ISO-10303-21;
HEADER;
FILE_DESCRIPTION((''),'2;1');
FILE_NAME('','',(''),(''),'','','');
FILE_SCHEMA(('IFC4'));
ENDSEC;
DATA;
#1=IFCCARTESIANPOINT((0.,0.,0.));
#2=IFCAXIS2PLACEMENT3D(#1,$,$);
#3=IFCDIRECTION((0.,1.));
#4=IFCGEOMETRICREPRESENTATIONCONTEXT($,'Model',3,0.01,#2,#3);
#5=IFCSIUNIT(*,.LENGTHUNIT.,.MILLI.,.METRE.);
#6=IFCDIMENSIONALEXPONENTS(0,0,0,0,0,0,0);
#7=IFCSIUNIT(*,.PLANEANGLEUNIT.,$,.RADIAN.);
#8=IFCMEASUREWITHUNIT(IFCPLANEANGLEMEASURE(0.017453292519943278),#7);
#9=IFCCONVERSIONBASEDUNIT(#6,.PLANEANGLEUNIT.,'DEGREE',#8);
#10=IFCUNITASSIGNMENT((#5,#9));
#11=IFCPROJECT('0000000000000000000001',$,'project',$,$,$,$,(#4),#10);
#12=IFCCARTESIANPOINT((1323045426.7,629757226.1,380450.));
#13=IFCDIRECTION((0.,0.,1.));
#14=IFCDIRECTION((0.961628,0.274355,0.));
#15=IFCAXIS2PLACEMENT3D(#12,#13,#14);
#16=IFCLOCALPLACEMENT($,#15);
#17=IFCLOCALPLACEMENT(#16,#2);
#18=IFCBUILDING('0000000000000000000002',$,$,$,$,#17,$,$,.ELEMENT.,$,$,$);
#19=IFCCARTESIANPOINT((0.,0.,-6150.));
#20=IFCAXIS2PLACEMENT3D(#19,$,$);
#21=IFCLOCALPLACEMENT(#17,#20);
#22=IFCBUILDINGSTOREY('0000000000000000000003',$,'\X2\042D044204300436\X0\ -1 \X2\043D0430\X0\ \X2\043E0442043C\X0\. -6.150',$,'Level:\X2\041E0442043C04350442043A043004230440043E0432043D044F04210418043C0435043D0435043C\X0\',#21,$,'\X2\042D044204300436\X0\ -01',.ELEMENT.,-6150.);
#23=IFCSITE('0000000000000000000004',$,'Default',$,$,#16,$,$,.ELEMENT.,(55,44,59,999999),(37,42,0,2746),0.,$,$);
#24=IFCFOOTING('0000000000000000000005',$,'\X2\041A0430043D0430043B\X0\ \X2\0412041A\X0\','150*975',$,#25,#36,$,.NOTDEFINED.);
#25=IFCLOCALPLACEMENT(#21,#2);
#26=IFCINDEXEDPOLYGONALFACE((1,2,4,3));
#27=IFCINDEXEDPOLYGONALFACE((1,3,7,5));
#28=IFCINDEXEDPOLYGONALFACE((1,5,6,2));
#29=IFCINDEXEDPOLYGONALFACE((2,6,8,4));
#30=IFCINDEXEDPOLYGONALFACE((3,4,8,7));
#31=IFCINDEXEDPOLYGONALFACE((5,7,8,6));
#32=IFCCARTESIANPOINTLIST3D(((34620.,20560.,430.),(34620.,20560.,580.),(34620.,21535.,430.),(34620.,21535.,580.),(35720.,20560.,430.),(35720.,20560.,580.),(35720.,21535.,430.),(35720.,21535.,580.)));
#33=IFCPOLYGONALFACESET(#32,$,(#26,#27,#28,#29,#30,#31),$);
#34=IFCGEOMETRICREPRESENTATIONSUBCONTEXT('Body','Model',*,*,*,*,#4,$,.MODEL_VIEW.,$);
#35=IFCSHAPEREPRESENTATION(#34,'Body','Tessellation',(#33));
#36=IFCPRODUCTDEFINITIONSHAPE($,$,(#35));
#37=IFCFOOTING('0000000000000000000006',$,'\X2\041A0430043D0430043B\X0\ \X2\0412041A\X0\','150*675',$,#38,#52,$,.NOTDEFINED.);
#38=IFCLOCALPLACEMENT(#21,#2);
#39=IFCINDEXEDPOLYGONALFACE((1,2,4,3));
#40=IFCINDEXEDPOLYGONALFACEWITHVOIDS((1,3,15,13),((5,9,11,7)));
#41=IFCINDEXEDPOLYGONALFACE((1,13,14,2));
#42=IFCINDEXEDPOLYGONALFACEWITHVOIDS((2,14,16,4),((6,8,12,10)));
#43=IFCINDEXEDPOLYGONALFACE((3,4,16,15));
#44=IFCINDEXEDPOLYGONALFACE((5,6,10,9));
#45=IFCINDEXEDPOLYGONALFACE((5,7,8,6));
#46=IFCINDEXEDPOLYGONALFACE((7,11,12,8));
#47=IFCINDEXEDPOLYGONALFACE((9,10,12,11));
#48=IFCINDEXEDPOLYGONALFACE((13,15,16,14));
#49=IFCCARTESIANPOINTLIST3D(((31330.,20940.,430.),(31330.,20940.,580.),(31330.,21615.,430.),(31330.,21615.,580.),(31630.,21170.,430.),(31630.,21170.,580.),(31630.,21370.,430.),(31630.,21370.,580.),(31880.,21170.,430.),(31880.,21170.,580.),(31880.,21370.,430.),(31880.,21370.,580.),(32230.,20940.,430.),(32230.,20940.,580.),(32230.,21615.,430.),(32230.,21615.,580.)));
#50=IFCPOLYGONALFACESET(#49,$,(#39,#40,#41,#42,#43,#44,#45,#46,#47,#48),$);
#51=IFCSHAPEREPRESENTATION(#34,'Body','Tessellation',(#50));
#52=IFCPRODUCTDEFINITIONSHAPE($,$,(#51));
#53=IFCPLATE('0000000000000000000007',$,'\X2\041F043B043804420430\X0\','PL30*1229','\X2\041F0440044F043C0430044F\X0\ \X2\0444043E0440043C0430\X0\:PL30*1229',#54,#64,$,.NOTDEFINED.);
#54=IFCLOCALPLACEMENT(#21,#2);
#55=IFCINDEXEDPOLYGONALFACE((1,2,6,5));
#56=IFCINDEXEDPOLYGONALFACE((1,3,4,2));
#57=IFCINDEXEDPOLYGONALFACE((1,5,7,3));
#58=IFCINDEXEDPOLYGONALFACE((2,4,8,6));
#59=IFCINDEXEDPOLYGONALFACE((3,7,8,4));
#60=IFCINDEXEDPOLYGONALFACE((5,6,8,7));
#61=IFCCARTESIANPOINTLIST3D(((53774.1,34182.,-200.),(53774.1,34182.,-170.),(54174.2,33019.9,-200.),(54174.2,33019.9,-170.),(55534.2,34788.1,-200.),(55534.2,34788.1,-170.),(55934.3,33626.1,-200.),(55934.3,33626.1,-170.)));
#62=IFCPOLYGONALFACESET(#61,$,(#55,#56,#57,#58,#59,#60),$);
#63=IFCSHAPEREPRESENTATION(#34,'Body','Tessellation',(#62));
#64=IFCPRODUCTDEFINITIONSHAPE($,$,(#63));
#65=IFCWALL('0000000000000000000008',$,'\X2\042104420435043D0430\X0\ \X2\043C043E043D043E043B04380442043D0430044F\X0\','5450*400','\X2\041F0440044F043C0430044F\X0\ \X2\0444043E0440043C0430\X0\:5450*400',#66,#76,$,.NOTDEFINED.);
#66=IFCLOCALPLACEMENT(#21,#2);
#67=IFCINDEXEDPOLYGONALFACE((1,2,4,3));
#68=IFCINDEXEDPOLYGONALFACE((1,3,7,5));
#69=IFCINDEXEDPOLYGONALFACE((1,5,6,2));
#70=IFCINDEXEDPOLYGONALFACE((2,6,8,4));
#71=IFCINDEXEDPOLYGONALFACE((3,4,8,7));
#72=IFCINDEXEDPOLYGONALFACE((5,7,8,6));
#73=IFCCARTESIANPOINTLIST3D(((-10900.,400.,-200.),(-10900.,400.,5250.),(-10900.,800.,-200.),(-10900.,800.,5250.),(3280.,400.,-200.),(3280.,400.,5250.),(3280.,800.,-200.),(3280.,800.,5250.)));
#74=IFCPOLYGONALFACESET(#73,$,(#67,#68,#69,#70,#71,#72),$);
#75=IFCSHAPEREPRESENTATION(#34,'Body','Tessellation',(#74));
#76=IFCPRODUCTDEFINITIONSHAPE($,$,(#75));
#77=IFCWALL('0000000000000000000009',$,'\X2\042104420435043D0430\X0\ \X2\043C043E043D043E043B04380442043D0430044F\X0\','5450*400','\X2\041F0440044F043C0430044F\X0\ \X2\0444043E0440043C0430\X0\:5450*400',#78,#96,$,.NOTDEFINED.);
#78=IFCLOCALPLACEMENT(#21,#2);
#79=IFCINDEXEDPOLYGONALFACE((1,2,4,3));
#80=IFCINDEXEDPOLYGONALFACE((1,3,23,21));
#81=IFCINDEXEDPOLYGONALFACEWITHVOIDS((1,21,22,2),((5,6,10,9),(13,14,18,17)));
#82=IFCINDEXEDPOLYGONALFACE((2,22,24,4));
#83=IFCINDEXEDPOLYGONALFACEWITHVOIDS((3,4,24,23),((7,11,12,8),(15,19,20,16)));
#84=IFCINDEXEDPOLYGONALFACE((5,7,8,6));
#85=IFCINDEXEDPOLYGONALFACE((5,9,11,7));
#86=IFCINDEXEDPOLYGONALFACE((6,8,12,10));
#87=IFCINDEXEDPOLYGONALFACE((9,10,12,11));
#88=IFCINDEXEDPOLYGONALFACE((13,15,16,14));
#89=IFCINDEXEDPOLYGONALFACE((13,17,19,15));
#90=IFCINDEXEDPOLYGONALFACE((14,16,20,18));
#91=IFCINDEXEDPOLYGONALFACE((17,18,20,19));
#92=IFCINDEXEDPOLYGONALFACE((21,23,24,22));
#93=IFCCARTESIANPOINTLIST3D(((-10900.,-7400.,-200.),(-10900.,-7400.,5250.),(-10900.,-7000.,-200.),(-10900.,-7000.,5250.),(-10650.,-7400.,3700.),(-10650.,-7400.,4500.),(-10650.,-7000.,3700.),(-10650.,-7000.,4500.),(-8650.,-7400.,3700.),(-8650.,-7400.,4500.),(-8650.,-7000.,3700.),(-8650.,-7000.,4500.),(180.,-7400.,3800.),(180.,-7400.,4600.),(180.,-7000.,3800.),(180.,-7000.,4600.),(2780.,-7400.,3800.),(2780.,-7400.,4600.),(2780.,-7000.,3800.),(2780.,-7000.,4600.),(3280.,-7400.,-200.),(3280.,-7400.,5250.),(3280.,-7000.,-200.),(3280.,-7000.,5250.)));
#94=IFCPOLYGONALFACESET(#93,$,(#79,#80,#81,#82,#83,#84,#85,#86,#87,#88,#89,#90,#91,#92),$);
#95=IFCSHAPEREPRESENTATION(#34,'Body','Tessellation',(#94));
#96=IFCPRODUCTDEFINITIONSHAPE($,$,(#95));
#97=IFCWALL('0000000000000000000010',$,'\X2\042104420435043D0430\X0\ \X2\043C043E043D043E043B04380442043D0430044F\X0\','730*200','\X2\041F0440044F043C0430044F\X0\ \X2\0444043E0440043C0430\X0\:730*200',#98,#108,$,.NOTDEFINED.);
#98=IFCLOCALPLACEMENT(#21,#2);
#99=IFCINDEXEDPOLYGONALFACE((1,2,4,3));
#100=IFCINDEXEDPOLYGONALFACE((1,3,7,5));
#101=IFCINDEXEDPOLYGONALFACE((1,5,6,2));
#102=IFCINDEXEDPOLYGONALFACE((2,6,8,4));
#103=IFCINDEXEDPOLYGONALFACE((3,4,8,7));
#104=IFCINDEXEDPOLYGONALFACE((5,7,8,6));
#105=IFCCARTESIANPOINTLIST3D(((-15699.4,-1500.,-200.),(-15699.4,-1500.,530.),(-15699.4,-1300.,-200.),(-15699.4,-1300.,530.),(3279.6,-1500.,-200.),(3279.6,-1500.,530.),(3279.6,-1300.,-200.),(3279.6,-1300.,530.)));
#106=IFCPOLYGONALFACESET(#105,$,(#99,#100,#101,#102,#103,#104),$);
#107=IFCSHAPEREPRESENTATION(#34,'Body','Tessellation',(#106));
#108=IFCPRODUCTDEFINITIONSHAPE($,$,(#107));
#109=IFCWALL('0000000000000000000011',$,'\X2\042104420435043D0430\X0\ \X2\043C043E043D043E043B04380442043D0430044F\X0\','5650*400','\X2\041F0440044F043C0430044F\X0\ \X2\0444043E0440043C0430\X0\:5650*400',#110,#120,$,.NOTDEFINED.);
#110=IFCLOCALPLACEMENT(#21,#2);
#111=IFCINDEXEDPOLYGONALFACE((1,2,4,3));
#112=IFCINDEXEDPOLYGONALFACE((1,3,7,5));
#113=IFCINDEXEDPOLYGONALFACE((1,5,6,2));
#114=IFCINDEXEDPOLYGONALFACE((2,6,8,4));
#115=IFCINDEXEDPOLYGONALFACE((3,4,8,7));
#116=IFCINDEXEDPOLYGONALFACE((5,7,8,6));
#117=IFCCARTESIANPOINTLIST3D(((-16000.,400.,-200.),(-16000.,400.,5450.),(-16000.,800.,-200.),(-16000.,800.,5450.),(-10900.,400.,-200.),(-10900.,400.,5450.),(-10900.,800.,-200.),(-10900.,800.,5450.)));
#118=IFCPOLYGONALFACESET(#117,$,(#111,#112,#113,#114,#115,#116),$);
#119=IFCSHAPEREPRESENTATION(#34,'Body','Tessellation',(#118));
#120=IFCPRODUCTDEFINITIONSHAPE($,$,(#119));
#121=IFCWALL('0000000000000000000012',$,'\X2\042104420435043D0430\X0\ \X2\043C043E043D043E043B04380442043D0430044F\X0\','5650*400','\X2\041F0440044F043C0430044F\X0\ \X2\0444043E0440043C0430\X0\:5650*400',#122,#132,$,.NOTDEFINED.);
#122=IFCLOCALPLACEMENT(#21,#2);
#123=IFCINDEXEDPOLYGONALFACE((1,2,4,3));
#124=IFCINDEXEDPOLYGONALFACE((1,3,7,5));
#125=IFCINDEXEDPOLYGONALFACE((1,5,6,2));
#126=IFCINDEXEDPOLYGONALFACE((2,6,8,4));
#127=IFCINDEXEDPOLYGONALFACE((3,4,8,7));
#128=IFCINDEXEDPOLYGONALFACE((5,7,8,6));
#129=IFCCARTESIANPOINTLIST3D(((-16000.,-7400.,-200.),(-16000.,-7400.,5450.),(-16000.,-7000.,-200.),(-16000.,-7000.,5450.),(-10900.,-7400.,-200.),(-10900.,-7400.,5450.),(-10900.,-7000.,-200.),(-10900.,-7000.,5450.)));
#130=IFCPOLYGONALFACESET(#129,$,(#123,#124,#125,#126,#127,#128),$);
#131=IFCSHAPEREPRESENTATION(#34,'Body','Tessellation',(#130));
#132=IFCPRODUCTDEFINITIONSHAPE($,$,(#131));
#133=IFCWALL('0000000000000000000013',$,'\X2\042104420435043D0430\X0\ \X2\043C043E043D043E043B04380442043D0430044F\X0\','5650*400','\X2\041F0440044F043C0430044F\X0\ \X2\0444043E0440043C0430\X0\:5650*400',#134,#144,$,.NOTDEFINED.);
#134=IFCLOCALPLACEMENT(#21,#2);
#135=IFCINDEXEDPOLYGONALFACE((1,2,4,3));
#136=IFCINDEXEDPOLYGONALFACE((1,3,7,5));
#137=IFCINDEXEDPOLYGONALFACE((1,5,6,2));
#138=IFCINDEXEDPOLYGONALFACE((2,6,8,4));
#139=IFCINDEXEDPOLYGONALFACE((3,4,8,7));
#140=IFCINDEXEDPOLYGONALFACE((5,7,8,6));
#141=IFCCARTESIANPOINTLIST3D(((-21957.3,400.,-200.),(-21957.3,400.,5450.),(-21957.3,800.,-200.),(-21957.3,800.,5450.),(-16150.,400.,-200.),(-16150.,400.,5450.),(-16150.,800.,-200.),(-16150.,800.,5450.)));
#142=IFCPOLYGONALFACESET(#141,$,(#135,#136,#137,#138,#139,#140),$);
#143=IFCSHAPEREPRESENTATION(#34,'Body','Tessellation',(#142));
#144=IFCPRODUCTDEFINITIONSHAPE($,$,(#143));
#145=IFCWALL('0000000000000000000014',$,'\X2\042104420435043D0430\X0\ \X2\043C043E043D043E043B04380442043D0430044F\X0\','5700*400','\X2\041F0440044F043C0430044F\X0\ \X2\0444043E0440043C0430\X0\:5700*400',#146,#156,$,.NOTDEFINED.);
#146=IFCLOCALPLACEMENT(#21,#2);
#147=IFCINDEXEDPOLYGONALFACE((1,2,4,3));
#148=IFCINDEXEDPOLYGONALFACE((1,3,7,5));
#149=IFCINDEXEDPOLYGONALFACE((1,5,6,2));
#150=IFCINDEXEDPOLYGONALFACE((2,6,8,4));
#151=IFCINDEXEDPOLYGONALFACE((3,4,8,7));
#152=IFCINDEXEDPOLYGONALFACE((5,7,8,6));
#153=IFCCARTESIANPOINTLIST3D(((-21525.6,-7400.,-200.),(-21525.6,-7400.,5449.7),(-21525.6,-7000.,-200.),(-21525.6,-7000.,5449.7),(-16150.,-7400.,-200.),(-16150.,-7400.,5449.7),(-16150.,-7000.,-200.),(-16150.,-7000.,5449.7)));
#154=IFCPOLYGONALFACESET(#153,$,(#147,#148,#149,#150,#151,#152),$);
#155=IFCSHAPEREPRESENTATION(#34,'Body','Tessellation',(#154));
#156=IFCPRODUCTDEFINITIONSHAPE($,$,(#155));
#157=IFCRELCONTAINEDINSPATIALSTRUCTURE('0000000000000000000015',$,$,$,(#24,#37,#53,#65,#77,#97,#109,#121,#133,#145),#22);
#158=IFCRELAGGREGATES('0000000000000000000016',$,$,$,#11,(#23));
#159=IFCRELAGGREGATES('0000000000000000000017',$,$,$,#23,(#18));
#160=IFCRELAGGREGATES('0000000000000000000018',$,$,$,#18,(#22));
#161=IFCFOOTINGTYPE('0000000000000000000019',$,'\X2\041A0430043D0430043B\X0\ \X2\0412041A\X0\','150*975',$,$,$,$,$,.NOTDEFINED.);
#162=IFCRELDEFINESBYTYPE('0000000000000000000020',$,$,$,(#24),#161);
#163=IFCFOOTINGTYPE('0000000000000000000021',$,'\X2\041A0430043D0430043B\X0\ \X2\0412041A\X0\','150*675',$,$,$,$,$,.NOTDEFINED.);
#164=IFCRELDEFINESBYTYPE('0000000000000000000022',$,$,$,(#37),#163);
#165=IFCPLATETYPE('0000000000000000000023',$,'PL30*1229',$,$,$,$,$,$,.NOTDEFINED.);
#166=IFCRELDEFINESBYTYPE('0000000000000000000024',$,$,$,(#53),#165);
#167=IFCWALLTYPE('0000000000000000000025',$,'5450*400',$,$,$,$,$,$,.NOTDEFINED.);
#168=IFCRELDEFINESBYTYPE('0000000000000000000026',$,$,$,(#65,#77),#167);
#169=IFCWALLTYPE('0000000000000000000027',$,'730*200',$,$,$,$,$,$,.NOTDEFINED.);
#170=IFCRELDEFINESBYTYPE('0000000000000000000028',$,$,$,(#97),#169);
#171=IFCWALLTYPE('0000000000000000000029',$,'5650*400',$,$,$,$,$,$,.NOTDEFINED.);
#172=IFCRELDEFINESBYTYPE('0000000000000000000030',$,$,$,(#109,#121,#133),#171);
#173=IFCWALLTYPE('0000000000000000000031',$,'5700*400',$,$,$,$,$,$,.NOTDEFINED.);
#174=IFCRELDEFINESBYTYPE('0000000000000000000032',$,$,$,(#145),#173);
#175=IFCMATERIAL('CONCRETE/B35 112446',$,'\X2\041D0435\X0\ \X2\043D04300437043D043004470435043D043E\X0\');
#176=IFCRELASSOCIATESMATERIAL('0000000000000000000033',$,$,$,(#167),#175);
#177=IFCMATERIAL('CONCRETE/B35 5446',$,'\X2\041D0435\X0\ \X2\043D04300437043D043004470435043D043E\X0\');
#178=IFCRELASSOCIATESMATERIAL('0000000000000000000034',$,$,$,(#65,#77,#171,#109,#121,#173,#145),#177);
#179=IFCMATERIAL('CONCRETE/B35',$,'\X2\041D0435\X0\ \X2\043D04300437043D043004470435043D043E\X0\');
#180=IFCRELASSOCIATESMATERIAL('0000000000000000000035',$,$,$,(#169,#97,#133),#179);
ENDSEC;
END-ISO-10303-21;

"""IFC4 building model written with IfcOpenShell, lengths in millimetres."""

from ifc_helpers import new_model, entity, si_unit, converted_unit, direction, frame, origin, place, context, subcontext, project, spatial, indexed_curve, outline, extrude, material, type_object, element, save


model = new_model("IFC4")

# Units and contexts
model_context = context("Model", 3, precision=0.01, world=origin(), true_north=direction((0.0, 1.0)))
body_context = subcontext(model_context, "Body", "Model", "MODEL_VIEW")
ifc_project = project(units=[si_unit("LENGTHUNIT", "METRE", prefix="MILLI"), converted_unit("PLANEANGLEUNIT", "DEGREE", entity("IfcPlaneAngleMeasure", 0.017453292519943278), si_unit("PLANEANGLEUNIT", "RADIAN"), dimensions=[0, 0, 0, 0, 0, 0, 0])], contexts=[model_context])

# Site, building, storey
site_placement = place(None, frame((1323045426.7, 629757226.1, 380450.0), z_axis=(0.0, 0.0, 1.0), x_axis=(0.961628, 0.274355, 0.0)))
site = spatial("IfcSite", under=ifc_project, at=site_placement, Name="Default", CompositionType="ELEMENT", RefLatitude=(55, 44, 59, 999999), RefLongitude=(37, 42, 0, 2746), RefElevation=0.0)
building_placement = place(site_placement, origin())
building = spatial("IfcBuilding", under=site, at=building_placement, CompositionType="ELEMENT")
storey_placement = place(building_placement, frame((0.0, 0.0, -6150.0)))
storey = spatial("IfcBuildingStorey", under=building, at=storey_placement, Name="Этаж -1 на отм. -6.150", ObjectType="Level:ОтметкаУровняСИменем", LongName="Этаж -01", CompositionType="ELEMENT", Elevation=-6150.0)

# Footings
footing_type_1 = type_object("IfcFootingType", Name="Канал ВК", Description="150*975", PredefinedType="NOTDEFINED")
footing_1_placement = place(storey_placement, origin())
element("IfcFooting", 1, at=footing_1_placement, inside=storey, type_object=footing_type_1, Name="Канал ВК", Description="150*975", PredefinedType="NOTDEFINED", context=body_context, shape_type="SweptSolid", body=[
    extrude(outline(indexed_curve([(-550.0, -487.5), (550.0, -487.5), (550.0, 487.5), (-550.0, 487.5), (-550.0, -487.5)], self_intersect=False)), frame((35170.0, 21047.5, 430.0), z_axis=(0.0, 0.0, 1.0), x_axis=(-1.0, 0.0, 0.0)), (0.0, 0.0, 1.0), 150.0),
])
footing_type_2 = type_object("IfcFootingType", Name="Канал ВК", Description="150*675", PredefinedType="NOTDEFINED")
footing_2_placement = place(storey_placement, origin())
element("IfcFooting", 2, at=footing_2_placement, inside=storey, type_object=footing_type_2, Name="Канал ВК", Description="150*675", PredefinedType="NOTDEFINED", context=body_context, shape_type="SweptSolid", body=[
    extrude(outline(indexed_curve([(-450.0, -337.5), (450.0, -337.5), (450.0, 337.5), (-450.0, 337.5), (-450.0, -337.5)], self_intersect=False), holes=[indexed_curve([(150.0, -92.5), (-100.0, -92.5), (-100.0, 107.5), (150.0, 107.5), (150.0, -92.5)], self_intersect=False)]), frame((31780.0, 21277.5, 430.0), z_axis=(0.0, 0.0, 1.0), x_axis=(-1.0, 0.0, 0.0)), (0.0, 0.0, 1.0), 150.0),
])

# Plate
plate_type_1 = type_object("IfcPlateType", Name="PL30*1229", PredefinedType="NOTDEFINED")
plate_1_placement = place(storey_placement, origin())
element("IfcPlate", 3, at=plate_1_placement, inside=storey, type_object=plate_type_1, Name="Плита", Description="PL30*1229", ObjectType="Прямая форма:PL30*1229", PredefinedType="NOTDEFINED", context=body_context, shape_type="SweptSolid", body=[
    extrude(outline(indexed_curve([(-930.8, -614.5), (930.7, -614.5), (930.8, 614.5), (-930.7, 614.5), (-930.8, -614.5)], self_intersect=False)), frame((54854.2, 33904.0, -200.0), z_axis=(0.0, 0.0, 1.0), x_axis=(0.945494, 0.325639, 0.0)), (0.0, 0.0, 1.0), 30.0),
])

# Wall
ifc_material_1 = material(Name="CONCRETE/B35 5446", Category="Не назначено")
ifc_material_2 = material(Name="CONCRETE/B35 112446", Category="Не назначено")
wall_type_1 = type_object("IfcWallType", Name="5450*400", PredefinedType="NOTDEFINED", material=ifc_material_2)
wall_1_placement = place(storey_placement, frame((-10900.0, 400.0, -200.0)))
element("IfcWall", 4, at=wall_1_placement, inside=storey, type_object=wall_type_1, material=ifc_material_1, Name="Стена монолитная", Description="5450*400", ObjectType="Прямая форма:5450*400", PredefinedType="NOTDEFINED", context=body_context, shape_type="SweptSolid", body=[
    extrude(outline(indexed_curve([(-200.0, -7090.0), (200.0, -7090.0), (200.0, 7090.0), (-200.0, 7090.0), (-200.0, -7090.0)], self_intersect=False)), frame((7090.0, 200.0, 0.0), z_axis=(0.0, 0.0, 1.0), x_axis=(0.0, -1.0, 0.0)), (0.0, 0.0, 1.0), 5450.0),
])

# Wall, openings
wall_2_placement = place(storey_placement, frame((-10900.0, -7400.0, -200.0)))
wall_2 = element("IfcWall", 5, at=wall_2_placement, inside=storey, type_object=wall_type_1, material=ifc_material_1, Name="Стена монолитная", Description="5450*400", ObjectType="Прямая форма:5450*400", PredefinedType="NOTDEFINED", context=body_context, shape_type="SweptSolid", body=[
    extrude(outline(indexed_curve([(-200.0, -7090.0), (200.0, -7090.0), (200.0, 7090.0), (-200.0, 7090.0), (-200.0, -7090.0)], self_intersect=False)), frame((7090.0, 200.0, 0.0), z_axis=(0.0, 0.0, 1.0), x_axis=(0.0, -1.0, 0.0)), (0.0, 0.0, 1.0), 5450.0),
])
opening_1_placement = place(storey_placement, frame((-10900.0, -7400.0, -200.0)))
element("IfcOpeningElement", 6, at=opening_1_placement, cuts=wall_2, PredefinedType="OPENING", context=body_context, shape_type="SweptSolid", body=[
    extrude(outline(indexed_curve([(-1300.0, -400.0), (1300.0, -400.0), (1300.0, 400.0), (-1300.0, 400.0), (-1300.0, -400.0)], self_intersect=False)), frame((12380.0, 400.0, 4400.0), z_axis=(0.0, -1.0, 0.0), x_axis=(1.0, 0.0, 0.0)), (0.0, 0.0, 1.0), 400.0),
])
opening_2_placement = place(storey_placement, frame((-10900.0, -7400.0, -200.0)))
element("IfcOpeningElement", 7, at=opening_2_placement, cuts=wall_2, PredefinedType="OPENING", context=body_context, shape_type="SweptSolid", body=[
    extrude(outline(indexed_curve([(-1000.0, -400.0), (1000.0, -400.0), (1000.0, 400.0), (-1000.0, 400.0), (-1000.0, -400.0)], self_intersect=False)), frame((1250.0, 400.0, 4300.0), z_axis=(0.0, -1.0, 0.0), x_axis=(1.0, 0.0, 0.0)), (0.0, 0.0, 1.0), 400.0),
])

# Walls
ifc_material_3 = material(Name="CONCRETE/B35", Category="Не назначено")
wall_type_2 = type_object("IfcWallType", Name="730*200", PredefinedType="NOTDEFINED", material=ifc_material_3)
wall_3_placement = place(storey_placement, frame((-15699.4, -1500.0, -200.0)))
element("IfcWall", 8, at=wall_3_placement, inside=storey, type_object=wall_type_2, material=ifc_material_3, Name="Стена монолитная", Description="730*200", ObjectType="Прямая форма:730*200", PredefinedType="NOTDEFINED", context=body_context, shape_type="SweptSolid", body=[
    extrude(outline(indexed_curve([(-9489.5, -100.0), (9489.5, -100.0), (9489.5, 100.0), (-9489.5, 100.0), (-9489.5, -100.0)], self_intersect=False)), frame((9489.5, 100.0, 0.0), z_axis=(0.0, 0.0, 1.0), x_axis=(-1.0, 0.0, 0.0)), (0.0, 0.0, 1.0), 730.0),
])
wall_type_3 = type_object("IfcWallType", Name="5650*400", PredefinedType="NOTDEFINED", material=ifc_material_1)
wall_4_placement = place(storey_placement, frame((-16000.0, 400.0, -200.0)))
element("IfcWall", 9, at=wall_4_placement, inside=storey, type_object=wall_type_3, material=ifc_material_1, Name="Стена монолитная", Description="5650*400", ObjectType="Прямая форма:5650*400", PredefinedType="NOTDEFINED", context=body_context, shape_type="SweptSolid", body=[
    extrude(outline(indexed_curve([(-200.0, -2550.0), (200.0, -2550.0), (200.0, 2550.0), (-200.0, 2550.0), (-200.0, -2550.0)], self_intersect=False)), frame((2550.0, 200.0, 0.0), z_axis=(0.0, 0.0, 1.0), x_axis=(0.0, -1.0, 0.0)), (0.0, 0.0, 1.0), 5650.0),
])
wall_5_placement = place(storey_placement, frame((-16000.0, -7400.0, -200.0)))
element("IfcWall", 10, at=wall_5_placement, inside=storey, type_object=wall_type_3, material=ifc_material_1, Name="Стена монолитная", Description="5650*400", ObjectType="Прямая форма:5650*400", PredefinedType="NOTDEFINED", context=body_context, shape_type="SweptSolid", body=[
    extrude(outline(indexed_curve([(-200.0, -2550.0), (200.0, -2550.0), (200.0, 2550.0), (-200.0, 2550.0), (-200.0, -2550.0)], self_intersect=False)), frame((2550.0, 200.0, 0.0), z_axis=(0.0, 0.0, 1.0), x_axis=(0.0, -1.0, 0.0)), (0.0, 0.0, 1.0), 5650.0),
])
wall_6_placement = place(storey_placement, frame((-21957.3, 400.0, -200.0)))
element("IfcWall", 11, at=wall_6_placement, inside=storey, type_object=wall_type_3, material=ifc_material_3, Name="Стена монолитная", Description="5650*400", ObjectType="Прямая форма:5650*400", PredefinedType="NOTDEFINED", context=body_context, shape_type="SweptSolid", body=[
    extrude(outline(indexed_curve([(-2903.6, -200.0), (2903.6, -200.0), (2903.6, 200.0), (-2903.6, 200.0), (-2903.6, -200.0)], self_intersect=False)), frame((2903.6, 200.0, 0.0), z_axis=(0.0, 0.0, 1.0), x_axis=(-1.0, 0.0, 0.0)), (0.0, 0.0, 1.0), 5650.0),
])
wall_type_4 = type_object("IfcWallType", Name="5700*400", PredefinedType="NOTDEFINED", material=ifc_material_1)
wall_7_placement = place(storey_placement, frame((-21525.6, -7400.0, -200.0)))
element("IfcWall", 12, at=wall_7_placement, inside=storey, type_object=wall_type_4, material=ifc_material_1, Name="Стена монолитная", Description="5700*400", ObjectType="Прямая форма:5700*400", PredefinedType="NOTDEFINED", context=body_context, shape_type="SweptSolid", body=[
    extrude(outline(indexed_curve([(-200.0, -2687.8), (200.0, -2687.8), (200.0, 2687.8), (-200.0, 2687.8), (-200.0, -2687.8)], self_intersect=False)), frame((2687.8, 200.0, 0.0), z_axis=(0.0, 0.0, 1.0), x_axis=(0.0, -1.0, 0.0)), (0.0, 0.0, 1.0), 5649.7),
])

save(model, "model.ifc")
